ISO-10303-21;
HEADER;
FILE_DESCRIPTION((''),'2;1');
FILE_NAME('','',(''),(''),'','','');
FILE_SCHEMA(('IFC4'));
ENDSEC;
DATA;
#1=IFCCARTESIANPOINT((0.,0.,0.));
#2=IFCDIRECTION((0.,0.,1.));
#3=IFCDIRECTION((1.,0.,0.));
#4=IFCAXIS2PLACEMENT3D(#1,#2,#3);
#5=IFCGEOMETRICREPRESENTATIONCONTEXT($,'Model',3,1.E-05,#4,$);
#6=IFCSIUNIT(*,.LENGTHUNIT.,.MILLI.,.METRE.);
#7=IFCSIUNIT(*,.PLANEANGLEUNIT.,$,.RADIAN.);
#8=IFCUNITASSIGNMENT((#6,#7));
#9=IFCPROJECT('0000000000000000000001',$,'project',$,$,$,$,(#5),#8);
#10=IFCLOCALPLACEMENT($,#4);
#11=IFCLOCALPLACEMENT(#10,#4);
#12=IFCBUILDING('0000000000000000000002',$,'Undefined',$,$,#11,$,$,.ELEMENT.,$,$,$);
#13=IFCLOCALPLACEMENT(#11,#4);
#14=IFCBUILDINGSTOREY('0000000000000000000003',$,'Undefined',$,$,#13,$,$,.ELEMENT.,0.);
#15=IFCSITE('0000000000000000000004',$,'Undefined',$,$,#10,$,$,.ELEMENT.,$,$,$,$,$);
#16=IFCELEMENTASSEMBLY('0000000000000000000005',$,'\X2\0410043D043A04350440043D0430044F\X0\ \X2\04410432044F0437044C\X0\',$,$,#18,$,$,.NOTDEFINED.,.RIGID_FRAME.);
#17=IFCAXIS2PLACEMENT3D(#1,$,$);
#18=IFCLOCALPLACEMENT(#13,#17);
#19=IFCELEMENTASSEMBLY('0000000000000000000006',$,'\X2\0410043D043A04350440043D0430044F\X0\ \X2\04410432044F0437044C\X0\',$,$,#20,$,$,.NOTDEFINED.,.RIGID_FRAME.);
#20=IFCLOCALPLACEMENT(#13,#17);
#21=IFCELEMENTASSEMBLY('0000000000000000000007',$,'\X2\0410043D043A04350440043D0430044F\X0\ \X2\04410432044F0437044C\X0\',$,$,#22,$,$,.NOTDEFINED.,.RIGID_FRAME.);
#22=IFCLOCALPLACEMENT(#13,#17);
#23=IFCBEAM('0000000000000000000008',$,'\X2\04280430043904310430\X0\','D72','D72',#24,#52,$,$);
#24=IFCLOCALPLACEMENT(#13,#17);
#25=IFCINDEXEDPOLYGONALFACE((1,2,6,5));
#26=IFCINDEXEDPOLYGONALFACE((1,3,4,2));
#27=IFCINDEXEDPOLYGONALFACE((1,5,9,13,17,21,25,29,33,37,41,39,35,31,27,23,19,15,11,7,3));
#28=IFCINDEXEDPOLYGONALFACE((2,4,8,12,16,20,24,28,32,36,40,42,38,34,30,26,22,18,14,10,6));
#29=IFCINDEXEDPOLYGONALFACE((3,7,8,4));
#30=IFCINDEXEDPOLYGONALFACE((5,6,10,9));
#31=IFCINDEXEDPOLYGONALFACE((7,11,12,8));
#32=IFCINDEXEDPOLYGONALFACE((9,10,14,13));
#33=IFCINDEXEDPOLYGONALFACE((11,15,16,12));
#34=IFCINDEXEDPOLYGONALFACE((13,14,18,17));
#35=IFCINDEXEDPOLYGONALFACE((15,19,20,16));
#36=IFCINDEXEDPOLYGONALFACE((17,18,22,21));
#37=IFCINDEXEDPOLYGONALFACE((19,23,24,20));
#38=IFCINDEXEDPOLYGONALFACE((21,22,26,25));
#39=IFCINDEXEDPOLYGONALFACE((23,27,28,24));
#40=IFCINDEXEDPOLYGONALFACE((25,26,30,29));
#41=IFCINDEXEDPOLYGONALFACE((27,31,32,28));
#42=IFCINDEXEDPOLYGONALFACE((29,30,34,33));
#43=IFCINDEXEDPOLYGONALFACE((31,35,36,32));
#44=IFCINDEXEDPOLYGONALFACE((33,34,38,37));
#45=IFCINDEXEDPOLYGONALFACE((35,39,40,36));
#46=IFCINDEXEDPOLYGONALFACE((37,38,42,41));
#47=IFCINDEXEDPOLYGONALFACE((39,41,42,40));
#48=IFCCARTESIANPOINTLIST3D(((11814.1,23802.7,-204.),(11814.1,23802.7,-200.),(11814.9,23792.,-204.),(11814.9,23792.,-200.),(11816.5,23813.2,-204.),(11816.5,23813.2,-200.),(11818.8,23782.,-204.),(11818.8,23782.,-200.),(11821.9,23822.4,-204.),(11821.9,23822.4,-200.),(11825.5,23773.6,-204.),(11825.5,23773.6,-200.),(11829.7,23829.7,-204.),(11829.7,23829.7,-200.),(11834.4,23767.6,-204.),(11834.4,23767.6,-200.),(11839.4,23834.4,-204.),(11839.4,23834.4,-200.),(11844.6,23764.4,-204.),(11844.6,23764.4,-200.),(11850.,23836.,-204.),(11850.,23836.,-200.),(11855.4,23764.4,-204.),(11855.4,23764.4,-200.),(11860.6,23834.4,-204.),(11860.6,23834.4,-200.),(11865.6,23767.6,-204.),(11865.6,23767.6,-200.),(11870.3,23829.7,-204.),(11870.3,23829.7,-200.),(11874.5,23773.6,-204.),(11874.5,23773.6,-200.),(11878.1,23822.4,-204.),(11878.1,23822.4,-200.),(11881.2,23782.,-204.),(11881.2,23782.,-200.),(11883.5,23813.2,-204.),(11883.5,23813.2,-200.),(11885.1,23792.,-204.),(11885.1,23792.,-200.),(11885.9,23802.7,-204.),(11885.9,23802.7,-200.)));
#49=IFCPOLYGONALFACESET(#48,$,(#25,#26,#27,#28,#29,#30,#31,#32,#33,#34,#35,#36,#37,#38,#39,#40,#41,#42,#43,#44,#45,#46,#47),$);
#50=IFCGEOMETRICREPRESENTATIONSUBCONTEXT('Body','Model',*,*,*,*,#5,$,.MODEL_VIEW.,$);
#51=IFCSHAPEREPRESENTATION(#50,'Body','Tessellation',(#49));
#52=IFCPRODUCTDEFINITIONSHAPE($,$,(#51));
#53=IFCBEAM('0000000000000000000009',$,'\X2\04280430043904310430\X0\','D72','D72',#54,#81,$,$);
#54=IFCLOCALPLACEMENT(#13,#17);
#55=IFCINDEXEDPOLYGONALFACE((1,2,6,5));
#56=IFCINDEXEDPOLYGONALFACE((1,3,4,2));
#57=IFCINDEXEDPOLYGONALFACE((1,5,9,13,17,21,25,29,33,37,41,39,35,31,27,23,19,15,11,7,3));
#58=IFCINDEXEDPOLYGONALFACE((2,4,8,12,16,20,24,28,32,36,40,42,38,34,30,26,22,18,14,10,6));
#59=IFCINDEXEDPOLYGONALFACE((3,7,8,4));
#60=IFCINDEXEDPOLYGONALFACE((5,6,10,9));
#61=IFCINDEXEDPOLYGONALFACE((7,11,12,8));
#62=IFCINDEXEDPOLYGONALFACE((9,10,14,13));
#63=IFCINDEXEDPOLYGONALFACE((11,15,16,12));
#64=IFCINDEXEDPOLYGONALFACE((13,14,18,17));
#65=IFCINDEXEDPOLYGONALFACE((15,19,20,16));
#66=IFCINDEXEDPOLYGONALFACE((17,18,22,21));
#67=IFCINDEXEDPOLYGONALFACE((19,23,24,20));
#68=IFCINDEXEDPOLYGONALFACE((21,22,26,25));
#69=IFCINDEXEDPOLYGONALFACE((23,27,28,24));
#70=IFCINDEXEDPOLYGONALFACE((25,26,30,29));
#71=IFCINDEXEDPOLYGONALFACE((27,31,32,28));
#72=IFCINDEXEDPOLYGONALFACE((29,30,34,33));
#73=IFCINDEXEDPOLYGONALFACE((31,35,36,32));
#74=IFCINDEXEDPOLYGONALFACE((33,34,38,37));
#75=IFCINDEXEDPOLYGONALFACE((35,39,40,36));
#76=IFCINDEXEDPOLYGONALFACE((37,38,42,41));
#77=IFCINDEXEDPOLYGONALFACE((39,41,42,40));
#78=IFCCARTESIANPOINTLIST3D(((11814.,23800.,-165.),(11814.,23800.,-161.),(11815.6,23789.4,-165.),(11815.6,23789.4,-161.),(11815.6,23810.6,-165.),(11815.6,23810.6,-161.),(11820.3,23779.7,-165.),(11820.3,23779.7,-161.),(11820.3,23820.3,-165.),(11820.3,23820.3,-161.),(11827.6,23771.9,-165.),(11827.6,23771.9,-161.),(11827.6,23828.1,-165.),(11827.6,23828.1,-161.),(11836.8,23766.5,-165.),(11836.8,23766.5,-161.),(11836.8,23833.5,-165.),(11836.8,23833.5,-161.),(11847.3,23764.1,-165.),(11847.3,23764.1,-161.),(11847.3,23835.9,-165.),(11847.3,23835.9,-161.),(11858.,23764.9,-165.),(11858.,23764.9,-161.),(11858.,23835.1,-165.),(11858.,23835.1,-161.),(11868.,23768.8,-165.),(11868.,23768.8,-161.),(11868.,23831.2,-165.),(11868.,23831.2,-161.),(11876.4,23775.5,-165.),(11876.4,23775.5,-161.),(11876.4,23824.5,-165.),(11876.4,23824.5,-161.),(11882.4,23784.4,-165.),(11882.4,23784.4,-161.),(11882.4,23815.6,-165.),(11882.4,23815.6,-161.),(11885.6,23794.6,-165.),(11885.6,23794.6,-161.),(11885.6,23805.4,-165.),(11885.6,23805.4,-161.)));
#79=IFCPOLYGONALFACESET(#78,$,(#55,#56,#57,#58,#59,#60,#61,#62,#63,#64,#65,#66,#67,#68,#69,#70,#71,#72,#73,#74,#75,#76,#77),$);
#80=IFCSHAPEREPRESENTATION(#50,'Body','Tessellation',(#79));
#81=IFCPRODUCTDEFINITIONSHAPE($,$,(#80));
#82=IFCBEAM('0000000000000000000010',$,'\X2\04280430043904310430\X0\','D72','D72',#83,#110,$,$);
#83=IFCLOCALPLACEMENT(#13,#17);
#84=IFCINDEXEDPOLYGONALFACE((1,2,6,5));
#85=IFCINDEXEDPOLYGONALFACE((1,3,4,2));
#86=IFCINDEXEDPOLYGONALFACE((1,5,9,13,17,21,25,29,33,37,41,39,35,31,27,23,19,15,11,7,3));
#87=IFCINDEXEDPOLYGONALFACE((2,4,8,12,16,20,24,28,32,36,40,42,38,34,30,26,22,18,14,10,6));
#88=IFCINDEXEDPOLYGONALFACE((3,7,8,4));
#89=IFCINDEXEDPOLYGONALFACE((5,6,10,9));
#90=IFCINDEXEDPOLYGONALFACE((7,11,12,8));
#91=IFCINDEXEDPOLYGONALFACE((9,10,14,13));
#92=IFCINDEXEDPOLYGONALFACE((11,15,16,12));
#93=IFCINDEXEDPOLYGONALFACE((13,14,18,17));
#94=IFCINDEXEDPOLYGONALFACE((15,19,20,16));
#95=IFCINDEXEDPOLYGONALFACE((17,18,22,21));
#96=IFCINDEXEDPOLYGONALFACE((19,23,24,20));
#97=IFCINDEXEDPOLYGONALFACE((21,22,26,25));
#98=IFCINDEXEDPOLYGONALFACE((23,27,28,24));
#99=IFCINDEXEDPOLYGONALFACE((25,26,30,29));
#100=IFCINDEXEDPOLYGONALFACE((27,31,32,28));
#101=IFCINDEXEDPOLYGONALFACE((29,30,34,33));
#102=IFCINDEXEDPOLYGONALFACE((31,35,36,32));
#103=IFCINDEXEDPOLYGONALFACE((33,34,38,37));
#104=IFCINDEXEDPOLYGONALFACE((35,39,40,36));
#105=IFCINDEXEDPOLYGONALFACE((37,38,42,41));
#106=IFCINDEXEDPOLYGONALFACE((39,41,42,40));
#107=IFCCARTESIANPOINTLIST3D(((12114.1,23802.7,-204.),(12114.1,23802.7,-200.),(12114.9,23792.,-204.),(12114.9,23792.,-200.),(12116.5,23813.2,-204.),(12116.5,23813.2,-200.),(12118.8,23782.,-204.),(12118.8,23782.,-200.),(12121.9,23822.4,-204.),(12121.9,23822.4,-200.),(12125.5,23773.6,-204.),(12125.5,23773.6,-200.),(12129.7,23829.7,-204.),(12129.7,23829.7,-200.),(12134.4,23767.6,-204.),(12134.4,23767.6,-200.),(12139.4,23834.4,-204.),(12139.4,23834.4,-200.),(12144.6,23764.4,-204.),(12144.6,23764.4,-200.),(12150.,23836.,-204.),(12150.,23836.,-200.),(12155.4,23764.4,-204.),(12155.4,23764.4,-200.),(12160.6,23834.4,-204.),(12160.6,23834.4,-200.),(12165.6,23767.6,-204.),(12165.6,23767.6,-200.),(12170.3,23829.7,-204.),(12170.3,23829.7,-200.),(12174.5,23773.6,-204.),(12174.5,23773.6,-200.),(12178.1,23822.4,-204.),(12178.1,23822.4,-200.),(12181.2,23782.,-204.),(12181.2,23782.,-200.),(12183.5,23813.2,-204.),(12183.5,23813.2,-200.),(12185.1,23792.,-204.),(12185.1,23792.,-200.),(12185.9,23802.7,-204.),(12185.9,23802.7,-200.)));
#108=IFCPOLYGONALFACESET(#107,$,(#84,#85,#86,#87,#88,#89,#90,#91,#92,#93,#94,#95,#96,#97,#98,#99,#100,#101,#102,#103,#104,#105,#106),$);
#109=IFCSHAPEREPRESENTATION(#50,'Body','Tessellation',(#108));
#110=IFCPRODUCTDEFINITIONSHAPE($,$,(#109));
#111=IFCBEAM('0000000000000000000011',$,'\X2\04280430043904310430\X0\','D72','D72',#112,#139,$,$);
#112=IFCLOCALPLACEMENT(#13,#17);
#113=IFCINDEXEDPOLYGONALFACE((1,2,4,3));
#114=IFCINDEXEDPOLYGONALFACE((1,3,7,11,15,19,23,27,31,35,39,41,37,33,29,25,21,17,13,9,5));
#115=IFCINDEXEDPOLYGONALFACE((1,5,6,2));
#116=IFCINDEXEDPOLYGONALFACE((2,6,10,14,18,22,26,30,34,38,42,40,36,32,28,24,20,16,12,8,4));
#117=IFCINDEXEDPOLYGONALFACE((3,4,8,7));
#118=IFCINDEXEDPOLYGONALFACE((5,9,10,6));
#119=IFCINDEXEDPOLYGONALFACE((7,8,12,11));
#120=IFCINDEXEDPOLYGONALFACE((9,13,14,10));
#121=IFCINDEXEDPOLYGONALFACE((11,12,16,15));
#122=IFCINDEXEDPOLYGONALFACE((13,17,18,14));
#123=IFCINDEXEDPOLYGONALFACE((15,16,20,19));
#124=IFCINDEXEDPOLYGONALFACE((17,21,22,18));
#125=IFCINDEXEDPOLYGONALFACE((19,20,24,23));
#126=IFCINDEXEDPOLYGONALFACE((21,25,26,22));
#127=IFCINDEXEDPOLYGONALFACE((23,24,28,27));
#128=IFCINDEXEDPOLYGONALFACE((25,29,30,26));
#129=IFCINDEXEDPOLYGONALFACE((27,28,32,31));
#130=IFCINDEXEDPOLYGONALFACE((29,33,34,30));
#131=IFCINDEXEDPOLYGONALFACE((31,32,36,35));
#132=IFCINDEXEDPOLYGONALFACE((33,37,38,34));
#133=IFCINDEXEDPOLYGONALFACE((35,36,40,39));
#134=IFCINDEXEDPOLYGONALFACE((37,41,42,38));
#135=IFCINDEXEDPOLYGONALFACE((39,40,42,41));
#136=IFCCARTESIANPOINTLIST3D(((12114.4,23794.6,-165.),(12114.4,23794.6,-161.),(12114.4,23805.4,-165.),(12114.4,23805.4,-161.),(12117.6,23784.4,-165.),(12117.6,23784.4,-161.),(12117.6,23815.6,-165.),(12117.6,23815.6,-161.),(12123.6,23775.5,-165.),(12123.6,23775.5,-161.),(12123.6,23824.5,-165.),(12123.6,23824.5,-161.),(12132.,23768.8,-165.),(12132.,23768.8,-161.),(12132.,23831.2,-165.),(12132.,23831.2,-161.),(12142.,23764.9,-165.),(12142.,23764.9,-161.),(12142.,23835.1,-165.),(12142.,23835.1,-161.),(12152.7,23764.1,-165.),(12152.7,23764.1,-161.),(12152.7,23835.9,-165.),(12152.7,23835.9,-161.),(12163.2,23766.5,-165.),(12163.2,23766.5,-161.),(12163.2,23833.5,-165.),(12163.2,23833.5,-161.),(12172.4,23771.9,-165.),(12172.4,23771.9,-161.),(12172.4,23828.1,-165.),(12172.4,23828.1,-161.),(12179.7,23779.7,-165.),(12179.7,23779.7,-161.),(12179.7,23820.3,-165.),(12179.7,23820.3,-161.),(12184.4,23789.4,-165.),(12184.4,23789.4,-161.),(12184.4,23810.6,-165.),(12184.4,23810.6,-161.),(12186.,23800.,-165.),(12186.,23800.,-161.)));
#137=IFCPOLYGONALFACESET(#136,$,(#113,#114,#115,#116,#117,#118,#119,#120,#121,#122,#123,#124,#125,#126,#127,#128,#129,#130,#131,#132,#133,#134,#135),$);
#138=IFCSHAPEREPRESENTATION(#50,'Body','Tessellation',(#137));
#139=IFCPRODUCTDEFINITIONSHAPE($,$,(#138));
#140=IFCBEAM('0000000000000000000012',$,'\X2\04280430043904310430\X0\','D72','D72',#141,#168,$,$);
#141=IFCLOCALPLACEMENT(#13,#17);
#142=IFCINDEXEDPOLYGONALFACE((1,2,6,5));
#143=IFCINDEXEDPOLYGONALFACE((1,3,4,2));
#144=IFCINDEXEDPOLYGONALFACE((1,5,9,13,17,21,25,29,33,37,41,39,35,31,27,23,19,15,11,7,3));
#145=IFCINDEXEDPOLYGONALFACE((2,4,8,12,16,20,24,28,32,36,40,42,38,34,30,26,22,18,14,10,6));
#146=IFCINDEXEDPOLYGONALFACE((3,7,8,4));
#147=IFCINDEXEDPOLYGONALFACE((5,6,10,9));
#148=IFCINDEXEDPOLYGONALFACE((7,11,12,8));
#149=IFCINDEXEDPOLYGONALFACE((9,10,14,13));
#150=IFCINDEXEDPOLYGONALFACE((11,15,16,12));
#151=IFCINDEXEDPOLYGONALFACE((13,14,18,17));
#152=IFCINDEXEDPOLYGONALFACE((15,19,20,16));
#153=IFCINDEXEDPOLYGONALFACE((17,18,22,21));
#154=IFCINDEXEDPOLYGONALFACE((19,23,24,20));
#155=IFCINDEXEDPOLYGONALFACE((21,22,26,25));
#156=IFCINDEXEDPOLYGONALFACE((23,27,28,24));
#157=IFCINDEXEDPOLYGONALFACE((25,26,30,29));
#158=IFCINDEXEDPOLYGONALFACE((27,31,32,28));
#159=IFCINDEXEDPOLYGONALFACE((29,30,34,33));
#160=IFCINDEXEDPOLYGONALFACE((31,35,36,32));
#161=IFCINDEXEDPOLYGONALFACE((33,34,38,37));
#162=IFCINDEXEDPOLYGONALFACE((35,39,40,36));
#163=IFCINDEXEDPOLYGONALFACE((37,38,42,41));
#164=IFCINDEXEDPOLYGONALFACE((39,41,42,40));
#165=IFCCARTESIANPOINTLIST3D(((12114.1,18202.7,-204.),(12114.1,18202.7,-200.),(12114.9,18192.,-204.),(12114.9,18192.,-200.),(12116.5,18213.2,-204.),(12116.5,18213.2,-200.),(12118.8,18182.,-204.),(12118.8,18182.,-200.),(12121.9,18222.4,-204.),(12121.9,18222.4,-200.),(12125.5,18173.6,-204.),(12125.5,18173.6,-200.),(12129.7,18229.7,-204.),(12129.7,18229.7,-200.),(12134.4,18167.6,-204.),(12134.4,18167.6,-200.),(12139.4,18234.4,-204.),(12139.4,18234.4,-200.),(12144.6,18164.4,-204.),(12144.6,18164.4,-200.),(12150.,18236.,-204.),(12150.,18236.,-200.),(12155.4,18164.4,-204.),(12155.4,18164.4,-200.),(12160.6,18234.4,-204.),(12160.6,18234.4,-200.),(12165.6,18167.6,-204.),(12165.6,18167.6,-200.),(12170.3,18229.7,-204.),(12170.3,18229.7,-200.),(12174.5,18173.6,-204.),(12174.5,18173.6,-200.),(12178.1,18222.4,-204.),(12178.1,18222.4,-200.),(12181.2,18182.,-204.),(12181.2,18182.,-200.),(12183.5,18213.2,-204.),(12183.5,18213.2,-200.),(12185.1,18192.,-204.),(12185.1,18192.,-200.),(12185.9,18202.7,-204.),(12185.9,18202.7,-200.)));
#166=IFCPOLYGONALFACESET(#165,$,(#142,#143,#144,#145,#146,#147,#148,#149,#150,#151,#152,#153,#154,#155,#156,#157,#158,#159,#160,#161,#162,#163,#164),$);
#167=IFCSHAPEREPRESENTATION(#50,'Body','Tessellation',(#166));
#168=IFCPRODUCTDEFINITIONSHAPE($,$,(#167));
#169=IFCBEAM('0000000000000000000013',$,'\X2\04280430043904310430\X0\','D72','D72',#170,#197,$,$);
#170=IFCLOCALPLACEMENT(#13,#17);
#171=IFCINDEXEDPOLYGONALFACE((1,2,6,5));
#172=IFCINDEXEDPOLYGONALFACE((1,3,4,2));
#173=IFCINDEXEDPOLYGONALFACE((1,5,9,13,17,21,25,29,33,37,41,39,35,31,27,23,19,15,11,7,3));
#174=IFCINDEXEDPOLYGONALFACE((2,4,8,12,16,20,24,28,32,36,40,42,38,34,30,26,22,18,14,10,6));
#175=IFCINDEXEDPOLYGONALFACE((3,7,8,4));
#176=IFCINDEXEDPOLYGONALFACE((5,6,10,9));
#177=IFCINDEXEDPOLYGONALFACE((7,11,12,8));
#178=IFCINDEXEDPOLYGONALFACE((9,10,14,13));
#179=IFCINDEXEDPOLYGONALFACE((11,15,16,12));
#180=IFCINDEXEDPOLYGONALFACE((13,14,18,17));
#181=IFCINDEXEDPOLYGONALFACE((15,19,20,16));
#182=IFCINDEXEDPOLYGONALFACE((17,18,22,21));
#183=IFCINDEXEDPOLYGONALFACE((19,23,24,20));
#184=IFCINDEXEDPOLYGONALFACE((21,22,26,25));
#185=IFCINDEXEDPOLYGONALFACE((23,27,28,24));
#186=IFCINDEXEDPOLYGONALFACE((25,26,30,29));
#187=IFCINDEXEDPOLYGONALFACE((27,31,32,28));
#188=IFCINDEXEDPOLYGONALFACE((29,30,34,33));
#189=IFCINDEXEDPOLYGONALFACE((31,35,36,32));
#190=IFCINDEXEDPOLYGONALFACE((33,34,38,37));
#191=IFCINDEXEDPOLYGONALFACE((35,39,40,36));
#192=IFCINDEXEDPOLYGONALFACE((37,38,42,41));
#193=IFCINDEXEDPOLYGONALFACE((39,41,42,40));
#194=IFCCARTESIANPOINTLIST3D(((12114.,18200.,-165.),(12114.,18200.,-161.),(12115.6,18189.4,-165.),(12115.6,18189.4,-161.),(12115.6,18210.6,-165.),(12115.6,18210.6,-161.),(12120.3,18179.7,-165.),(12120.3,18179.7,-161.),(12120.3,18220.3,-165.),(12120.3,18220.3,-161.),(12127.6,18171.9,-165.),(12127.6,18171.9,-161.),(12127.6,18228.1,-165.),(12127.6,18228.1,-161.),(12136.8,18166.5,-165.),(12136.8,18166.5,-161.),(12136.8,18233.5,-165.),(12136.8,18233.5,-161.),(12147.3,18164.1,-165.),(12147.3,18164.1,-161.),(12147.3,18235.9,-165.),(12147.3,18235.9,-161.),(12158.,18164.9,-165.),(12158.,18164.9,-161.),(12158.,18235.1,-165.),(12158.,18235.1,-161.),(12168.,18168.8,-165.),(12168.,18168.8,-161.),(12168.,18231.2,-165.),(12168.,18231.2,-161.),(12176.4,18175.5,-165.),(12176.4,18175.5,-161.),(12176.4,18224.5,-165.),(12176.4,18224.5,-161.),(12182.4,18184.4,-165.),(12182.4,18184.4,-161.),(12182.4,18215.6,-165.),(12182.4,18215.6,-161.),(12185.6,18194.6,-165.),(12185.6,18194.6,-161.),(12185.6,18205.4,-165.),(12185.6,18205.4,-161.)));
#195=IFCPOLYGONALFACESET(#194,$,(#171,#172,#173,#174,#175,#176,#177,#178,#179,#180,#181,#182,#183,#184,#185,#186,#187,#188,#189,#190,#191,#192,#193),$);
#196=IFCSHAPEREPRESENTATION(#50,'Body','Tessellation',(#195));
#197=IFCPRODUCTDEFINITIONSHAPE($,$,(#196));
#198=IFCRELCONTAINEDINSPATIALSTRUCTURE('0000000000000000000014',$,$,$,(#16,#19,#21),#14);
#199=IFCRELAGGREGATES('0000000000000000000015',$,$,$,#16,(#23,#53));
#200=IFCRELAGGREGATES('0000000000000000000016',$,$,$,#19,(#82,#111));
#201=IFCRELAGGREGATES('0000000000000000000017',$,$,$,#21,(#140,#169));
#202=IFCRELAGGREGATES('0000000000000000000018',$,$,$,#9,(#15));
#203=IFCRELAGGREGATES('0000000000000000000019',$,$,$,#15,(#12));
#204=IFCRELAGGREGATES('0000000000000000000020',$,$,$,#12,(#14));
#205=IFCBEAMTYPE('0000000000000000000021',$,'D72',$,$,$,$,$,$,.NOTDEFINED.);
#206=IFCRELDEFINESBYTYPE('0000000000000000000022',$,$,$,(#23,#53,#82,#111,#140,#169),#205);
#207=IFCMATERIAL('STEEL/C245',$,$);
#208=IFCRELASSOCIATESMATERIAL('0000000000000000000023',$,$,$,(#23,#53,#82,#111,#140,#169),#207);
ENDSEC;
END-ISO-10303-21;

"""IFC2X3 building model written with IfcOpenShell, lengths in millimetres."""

from ifc_helpers import new_model, si_unit, frame, origin_with_axes, origin_2d_with_axis, place, context, subcontext, project, spatial, circle, extrude, material, type_object, element, aggregate, save


model = new_model("IFC2X3")

# Units and contexts
model_context = context("Model", 3, precision=1e-05, world=origin_with_axes())
body_context = subcontext(model_context, "Body", "Model", "MODEL_VIEW")
ifc_project = project(units=[si_unit("LENGTHUNIT", "METRE", prefix="MILLI"), si_unit("PLANEANGLEUNIT", "RADIAN")], contexts=[model_context])

# Site, building, storey
site_placement = place(None, origin_with_axes())
site = spatial("IfcSite", under=ifc_project, at=site_placement, Name="Undefined", CompositionType="ELEMENT")
building_placement = place(site_placement, origin_with_axes())
building = spatial("IfcBuilding", under=site, at=building_placement, Name="Undefined", CompositionType="ELEMENT")
storey_placement = place(building_placement, origin_with_axes())
storey = spatial("IfcBuildingStorey", under=building, at=storey_placement, Name="Undefined", CompositionType="ELEMENT", Elevation=0.0)

# Shared definitions
ifc_material_1 = material(Name="STEEL/C245")

# Element assemblies
assembly_1_placement = place(storey_placement, origin_with_axes())
assembly_1 = element("IfcElementAssembly", 1, at=assembly_1_placement, inside=storey, Name="Анкерная связь", AssemblyPlace="NOTDEFINED", PredefinedType="RIGID_FRAME")
assembly_2_placement = place(storey_placement, origin_with_axes())
assembly_2 = element("IfcElementAssembly", 2, at=assembly_2_placement, inside=storey, Name="Анкерная связь", AssemblyPlace="NOTDEFINED", PredefinedType="RIGID_FRAME")
assembly_3_placement = place(storey_placement, origin_with_axes())
assembly_3 = element("IfcElementAssembly", 3, at=assembly_3_placement, inside=storey, Name="Анкерная связь", AssemblyPlace="NOTDEFINED", PredefinedType="RIGID_FRAME")

# Beams
beam_type_1 = type_object("IfcBeamType", Name="D72", PredefinedType="NOTDEFINED")
beam_1_placement = place(assembly_1_placement, frame((11850.0, 23800.0, -200.0), z_axis=(-1.0, 0.0, 0.0), x_axis=(0.0, 0.0, -1.0)))
beam_1 = element("IfcBeam", 4, at=beam_1_placement, type_object=beam_type_1, material=ifc_material_1, Name="Шайба", Description="D72", ObjectType="D72", context=body_context, shape_type="SweptSolid", body=[
    extrude(circle(Radius=36.0, at=origin_2d_with_axis()), frame((4.0, 0.0, 0.0), z_axis=(-1.0, 0.0, 0.0), x_axis=(0.0, -1.0, 0.0)), (0.0, 0.0, 1.0), 4.0),
])
beam_2_placement = place(assembly_1_placement, frame((11850.0, 23800.0, -161.0), z_axis=(0.0, -1.0, 0.0), x_axis=(0.0, 0.0, -1.0)))
beam_2 = element("IfcBeam", 5, at=beam_2_placement, type_object=beam_type_1, material=ifc_material_1, Name="Шайба", Description="D72", ObjectType="D72", context=body_context, shape_type="SweptSolid", body=[
    extrude(circle(Radius=36.0, at=origin_2d_with_axis()), frame((4.0, 0.0, 0.0), z_axis=(-1.0, 0.0, 0.0), x_axis=(0.0, -1.0, 0.0)), (0.0, 0.0, 1.0), 4.0),
])
beam_3_placement = place(assembly_2_placement, frame((12150.0, 23800.0, -200.0), z_axis=(-1.0, 0.0, 0.0), x_axis=(0.0, 0.0, -1.0)))
beam_3 = element("IfcBeam", 6, at=beam_3_placement, type_object=beam_type_1, material=ifc_material_1, Name="Шайба", Description="D72", ObjectType="D72", context=body_context, shape_type="SweptSolid", body=[
    extrude(circle(Radius=36.0, at=origin_2d_with_axis()), frame((4.0, 0.0, 0.0), z_axis=(-1.0, 0.0, 0.0), x_axis=(0.0, -1.0, 0.0)), (0.0, 0.0, 1.0), 4.0),
])
beam_4_placement = place(assembly_2_placement, frame((12150.0, 23800.0, -161.0), z_axis=(0.0, 1.0, 0.0), x_axis=(0.0, 0.0, -1.0)))
beam_4 = element("IfcBeam", 7, at=beam_4_placement, type_object=beam_type_1, material=ifc_material_1, Name="Шайба", Description="D72", ObjectType="D72", context=body_context, shape_type="SweptSolid", body=[
    extrude(circle(Radius=36.0, at=origin_2d_with_axis()), frame((4.0, 0.0, 0.0), z_axis=(-1.0, 0.0, 0.0), x_axis=(0.0, -1.0, 0.0)), (0.0, 0.0, 1.0), 4.0),
])
beam_5_placement = place(assembly_3_placement, frame((12150.0, 18200.0, -200.0), z_axis=(-1.0, 0.0, 0.0), x_axis=(0.0, 0.0, -1.0)))
beam_5 = element("IfcBeam", 8, at=beam_5_placement, type_object=beam_type_1, material=ifc_material_1, Name="Шайба", Description="D72", ObjectType="D72", context=body_context, shape_type="SweptSolid", body=[
    extrude(circle(Radius=36.0, at=origin_2d_with_axis()), frame((4.0, 0.0, 0.0), z_axis=(-1.0, 0.0, 0.0), x_axis=(0.0, -1.0, 0.0)), (0.0, 0.0, 1.0), 4.0),
])
beam_6_placement = place(assembly_3_placement, frame((12150.0, 18200.0, -161.0), z_axis=(0.0, -1.0, 0.0), x_axis=(0.0, 0.0, -1.0)))
beam_6 = element("IfcBeam", 9, at=beam_6_placement, type_object=beam_type_1, material=ifc_material_1, Name="Шайба", Description="D72", ObjectType="D72", context=body_context, shape_type="SweptSolid", body=[
    extrude(circle(Radius=36.0, at=origin_2d_with_axis()), frame((4.0, 0.0, 0.0), z_axis=(-1.0, 0.0, 0.0), x_axis=(0.0, -1.0, 0.0)), (0.0, 0.0, 1.0), 4.0),
])

aggregate(assembly_1, [beam_1, beam_2])
aggregate(assembly_2, [beam_3, beam_4])
aggregate(assembly_3, [beam_5, beam_6])

save(model, "model.ifc")
